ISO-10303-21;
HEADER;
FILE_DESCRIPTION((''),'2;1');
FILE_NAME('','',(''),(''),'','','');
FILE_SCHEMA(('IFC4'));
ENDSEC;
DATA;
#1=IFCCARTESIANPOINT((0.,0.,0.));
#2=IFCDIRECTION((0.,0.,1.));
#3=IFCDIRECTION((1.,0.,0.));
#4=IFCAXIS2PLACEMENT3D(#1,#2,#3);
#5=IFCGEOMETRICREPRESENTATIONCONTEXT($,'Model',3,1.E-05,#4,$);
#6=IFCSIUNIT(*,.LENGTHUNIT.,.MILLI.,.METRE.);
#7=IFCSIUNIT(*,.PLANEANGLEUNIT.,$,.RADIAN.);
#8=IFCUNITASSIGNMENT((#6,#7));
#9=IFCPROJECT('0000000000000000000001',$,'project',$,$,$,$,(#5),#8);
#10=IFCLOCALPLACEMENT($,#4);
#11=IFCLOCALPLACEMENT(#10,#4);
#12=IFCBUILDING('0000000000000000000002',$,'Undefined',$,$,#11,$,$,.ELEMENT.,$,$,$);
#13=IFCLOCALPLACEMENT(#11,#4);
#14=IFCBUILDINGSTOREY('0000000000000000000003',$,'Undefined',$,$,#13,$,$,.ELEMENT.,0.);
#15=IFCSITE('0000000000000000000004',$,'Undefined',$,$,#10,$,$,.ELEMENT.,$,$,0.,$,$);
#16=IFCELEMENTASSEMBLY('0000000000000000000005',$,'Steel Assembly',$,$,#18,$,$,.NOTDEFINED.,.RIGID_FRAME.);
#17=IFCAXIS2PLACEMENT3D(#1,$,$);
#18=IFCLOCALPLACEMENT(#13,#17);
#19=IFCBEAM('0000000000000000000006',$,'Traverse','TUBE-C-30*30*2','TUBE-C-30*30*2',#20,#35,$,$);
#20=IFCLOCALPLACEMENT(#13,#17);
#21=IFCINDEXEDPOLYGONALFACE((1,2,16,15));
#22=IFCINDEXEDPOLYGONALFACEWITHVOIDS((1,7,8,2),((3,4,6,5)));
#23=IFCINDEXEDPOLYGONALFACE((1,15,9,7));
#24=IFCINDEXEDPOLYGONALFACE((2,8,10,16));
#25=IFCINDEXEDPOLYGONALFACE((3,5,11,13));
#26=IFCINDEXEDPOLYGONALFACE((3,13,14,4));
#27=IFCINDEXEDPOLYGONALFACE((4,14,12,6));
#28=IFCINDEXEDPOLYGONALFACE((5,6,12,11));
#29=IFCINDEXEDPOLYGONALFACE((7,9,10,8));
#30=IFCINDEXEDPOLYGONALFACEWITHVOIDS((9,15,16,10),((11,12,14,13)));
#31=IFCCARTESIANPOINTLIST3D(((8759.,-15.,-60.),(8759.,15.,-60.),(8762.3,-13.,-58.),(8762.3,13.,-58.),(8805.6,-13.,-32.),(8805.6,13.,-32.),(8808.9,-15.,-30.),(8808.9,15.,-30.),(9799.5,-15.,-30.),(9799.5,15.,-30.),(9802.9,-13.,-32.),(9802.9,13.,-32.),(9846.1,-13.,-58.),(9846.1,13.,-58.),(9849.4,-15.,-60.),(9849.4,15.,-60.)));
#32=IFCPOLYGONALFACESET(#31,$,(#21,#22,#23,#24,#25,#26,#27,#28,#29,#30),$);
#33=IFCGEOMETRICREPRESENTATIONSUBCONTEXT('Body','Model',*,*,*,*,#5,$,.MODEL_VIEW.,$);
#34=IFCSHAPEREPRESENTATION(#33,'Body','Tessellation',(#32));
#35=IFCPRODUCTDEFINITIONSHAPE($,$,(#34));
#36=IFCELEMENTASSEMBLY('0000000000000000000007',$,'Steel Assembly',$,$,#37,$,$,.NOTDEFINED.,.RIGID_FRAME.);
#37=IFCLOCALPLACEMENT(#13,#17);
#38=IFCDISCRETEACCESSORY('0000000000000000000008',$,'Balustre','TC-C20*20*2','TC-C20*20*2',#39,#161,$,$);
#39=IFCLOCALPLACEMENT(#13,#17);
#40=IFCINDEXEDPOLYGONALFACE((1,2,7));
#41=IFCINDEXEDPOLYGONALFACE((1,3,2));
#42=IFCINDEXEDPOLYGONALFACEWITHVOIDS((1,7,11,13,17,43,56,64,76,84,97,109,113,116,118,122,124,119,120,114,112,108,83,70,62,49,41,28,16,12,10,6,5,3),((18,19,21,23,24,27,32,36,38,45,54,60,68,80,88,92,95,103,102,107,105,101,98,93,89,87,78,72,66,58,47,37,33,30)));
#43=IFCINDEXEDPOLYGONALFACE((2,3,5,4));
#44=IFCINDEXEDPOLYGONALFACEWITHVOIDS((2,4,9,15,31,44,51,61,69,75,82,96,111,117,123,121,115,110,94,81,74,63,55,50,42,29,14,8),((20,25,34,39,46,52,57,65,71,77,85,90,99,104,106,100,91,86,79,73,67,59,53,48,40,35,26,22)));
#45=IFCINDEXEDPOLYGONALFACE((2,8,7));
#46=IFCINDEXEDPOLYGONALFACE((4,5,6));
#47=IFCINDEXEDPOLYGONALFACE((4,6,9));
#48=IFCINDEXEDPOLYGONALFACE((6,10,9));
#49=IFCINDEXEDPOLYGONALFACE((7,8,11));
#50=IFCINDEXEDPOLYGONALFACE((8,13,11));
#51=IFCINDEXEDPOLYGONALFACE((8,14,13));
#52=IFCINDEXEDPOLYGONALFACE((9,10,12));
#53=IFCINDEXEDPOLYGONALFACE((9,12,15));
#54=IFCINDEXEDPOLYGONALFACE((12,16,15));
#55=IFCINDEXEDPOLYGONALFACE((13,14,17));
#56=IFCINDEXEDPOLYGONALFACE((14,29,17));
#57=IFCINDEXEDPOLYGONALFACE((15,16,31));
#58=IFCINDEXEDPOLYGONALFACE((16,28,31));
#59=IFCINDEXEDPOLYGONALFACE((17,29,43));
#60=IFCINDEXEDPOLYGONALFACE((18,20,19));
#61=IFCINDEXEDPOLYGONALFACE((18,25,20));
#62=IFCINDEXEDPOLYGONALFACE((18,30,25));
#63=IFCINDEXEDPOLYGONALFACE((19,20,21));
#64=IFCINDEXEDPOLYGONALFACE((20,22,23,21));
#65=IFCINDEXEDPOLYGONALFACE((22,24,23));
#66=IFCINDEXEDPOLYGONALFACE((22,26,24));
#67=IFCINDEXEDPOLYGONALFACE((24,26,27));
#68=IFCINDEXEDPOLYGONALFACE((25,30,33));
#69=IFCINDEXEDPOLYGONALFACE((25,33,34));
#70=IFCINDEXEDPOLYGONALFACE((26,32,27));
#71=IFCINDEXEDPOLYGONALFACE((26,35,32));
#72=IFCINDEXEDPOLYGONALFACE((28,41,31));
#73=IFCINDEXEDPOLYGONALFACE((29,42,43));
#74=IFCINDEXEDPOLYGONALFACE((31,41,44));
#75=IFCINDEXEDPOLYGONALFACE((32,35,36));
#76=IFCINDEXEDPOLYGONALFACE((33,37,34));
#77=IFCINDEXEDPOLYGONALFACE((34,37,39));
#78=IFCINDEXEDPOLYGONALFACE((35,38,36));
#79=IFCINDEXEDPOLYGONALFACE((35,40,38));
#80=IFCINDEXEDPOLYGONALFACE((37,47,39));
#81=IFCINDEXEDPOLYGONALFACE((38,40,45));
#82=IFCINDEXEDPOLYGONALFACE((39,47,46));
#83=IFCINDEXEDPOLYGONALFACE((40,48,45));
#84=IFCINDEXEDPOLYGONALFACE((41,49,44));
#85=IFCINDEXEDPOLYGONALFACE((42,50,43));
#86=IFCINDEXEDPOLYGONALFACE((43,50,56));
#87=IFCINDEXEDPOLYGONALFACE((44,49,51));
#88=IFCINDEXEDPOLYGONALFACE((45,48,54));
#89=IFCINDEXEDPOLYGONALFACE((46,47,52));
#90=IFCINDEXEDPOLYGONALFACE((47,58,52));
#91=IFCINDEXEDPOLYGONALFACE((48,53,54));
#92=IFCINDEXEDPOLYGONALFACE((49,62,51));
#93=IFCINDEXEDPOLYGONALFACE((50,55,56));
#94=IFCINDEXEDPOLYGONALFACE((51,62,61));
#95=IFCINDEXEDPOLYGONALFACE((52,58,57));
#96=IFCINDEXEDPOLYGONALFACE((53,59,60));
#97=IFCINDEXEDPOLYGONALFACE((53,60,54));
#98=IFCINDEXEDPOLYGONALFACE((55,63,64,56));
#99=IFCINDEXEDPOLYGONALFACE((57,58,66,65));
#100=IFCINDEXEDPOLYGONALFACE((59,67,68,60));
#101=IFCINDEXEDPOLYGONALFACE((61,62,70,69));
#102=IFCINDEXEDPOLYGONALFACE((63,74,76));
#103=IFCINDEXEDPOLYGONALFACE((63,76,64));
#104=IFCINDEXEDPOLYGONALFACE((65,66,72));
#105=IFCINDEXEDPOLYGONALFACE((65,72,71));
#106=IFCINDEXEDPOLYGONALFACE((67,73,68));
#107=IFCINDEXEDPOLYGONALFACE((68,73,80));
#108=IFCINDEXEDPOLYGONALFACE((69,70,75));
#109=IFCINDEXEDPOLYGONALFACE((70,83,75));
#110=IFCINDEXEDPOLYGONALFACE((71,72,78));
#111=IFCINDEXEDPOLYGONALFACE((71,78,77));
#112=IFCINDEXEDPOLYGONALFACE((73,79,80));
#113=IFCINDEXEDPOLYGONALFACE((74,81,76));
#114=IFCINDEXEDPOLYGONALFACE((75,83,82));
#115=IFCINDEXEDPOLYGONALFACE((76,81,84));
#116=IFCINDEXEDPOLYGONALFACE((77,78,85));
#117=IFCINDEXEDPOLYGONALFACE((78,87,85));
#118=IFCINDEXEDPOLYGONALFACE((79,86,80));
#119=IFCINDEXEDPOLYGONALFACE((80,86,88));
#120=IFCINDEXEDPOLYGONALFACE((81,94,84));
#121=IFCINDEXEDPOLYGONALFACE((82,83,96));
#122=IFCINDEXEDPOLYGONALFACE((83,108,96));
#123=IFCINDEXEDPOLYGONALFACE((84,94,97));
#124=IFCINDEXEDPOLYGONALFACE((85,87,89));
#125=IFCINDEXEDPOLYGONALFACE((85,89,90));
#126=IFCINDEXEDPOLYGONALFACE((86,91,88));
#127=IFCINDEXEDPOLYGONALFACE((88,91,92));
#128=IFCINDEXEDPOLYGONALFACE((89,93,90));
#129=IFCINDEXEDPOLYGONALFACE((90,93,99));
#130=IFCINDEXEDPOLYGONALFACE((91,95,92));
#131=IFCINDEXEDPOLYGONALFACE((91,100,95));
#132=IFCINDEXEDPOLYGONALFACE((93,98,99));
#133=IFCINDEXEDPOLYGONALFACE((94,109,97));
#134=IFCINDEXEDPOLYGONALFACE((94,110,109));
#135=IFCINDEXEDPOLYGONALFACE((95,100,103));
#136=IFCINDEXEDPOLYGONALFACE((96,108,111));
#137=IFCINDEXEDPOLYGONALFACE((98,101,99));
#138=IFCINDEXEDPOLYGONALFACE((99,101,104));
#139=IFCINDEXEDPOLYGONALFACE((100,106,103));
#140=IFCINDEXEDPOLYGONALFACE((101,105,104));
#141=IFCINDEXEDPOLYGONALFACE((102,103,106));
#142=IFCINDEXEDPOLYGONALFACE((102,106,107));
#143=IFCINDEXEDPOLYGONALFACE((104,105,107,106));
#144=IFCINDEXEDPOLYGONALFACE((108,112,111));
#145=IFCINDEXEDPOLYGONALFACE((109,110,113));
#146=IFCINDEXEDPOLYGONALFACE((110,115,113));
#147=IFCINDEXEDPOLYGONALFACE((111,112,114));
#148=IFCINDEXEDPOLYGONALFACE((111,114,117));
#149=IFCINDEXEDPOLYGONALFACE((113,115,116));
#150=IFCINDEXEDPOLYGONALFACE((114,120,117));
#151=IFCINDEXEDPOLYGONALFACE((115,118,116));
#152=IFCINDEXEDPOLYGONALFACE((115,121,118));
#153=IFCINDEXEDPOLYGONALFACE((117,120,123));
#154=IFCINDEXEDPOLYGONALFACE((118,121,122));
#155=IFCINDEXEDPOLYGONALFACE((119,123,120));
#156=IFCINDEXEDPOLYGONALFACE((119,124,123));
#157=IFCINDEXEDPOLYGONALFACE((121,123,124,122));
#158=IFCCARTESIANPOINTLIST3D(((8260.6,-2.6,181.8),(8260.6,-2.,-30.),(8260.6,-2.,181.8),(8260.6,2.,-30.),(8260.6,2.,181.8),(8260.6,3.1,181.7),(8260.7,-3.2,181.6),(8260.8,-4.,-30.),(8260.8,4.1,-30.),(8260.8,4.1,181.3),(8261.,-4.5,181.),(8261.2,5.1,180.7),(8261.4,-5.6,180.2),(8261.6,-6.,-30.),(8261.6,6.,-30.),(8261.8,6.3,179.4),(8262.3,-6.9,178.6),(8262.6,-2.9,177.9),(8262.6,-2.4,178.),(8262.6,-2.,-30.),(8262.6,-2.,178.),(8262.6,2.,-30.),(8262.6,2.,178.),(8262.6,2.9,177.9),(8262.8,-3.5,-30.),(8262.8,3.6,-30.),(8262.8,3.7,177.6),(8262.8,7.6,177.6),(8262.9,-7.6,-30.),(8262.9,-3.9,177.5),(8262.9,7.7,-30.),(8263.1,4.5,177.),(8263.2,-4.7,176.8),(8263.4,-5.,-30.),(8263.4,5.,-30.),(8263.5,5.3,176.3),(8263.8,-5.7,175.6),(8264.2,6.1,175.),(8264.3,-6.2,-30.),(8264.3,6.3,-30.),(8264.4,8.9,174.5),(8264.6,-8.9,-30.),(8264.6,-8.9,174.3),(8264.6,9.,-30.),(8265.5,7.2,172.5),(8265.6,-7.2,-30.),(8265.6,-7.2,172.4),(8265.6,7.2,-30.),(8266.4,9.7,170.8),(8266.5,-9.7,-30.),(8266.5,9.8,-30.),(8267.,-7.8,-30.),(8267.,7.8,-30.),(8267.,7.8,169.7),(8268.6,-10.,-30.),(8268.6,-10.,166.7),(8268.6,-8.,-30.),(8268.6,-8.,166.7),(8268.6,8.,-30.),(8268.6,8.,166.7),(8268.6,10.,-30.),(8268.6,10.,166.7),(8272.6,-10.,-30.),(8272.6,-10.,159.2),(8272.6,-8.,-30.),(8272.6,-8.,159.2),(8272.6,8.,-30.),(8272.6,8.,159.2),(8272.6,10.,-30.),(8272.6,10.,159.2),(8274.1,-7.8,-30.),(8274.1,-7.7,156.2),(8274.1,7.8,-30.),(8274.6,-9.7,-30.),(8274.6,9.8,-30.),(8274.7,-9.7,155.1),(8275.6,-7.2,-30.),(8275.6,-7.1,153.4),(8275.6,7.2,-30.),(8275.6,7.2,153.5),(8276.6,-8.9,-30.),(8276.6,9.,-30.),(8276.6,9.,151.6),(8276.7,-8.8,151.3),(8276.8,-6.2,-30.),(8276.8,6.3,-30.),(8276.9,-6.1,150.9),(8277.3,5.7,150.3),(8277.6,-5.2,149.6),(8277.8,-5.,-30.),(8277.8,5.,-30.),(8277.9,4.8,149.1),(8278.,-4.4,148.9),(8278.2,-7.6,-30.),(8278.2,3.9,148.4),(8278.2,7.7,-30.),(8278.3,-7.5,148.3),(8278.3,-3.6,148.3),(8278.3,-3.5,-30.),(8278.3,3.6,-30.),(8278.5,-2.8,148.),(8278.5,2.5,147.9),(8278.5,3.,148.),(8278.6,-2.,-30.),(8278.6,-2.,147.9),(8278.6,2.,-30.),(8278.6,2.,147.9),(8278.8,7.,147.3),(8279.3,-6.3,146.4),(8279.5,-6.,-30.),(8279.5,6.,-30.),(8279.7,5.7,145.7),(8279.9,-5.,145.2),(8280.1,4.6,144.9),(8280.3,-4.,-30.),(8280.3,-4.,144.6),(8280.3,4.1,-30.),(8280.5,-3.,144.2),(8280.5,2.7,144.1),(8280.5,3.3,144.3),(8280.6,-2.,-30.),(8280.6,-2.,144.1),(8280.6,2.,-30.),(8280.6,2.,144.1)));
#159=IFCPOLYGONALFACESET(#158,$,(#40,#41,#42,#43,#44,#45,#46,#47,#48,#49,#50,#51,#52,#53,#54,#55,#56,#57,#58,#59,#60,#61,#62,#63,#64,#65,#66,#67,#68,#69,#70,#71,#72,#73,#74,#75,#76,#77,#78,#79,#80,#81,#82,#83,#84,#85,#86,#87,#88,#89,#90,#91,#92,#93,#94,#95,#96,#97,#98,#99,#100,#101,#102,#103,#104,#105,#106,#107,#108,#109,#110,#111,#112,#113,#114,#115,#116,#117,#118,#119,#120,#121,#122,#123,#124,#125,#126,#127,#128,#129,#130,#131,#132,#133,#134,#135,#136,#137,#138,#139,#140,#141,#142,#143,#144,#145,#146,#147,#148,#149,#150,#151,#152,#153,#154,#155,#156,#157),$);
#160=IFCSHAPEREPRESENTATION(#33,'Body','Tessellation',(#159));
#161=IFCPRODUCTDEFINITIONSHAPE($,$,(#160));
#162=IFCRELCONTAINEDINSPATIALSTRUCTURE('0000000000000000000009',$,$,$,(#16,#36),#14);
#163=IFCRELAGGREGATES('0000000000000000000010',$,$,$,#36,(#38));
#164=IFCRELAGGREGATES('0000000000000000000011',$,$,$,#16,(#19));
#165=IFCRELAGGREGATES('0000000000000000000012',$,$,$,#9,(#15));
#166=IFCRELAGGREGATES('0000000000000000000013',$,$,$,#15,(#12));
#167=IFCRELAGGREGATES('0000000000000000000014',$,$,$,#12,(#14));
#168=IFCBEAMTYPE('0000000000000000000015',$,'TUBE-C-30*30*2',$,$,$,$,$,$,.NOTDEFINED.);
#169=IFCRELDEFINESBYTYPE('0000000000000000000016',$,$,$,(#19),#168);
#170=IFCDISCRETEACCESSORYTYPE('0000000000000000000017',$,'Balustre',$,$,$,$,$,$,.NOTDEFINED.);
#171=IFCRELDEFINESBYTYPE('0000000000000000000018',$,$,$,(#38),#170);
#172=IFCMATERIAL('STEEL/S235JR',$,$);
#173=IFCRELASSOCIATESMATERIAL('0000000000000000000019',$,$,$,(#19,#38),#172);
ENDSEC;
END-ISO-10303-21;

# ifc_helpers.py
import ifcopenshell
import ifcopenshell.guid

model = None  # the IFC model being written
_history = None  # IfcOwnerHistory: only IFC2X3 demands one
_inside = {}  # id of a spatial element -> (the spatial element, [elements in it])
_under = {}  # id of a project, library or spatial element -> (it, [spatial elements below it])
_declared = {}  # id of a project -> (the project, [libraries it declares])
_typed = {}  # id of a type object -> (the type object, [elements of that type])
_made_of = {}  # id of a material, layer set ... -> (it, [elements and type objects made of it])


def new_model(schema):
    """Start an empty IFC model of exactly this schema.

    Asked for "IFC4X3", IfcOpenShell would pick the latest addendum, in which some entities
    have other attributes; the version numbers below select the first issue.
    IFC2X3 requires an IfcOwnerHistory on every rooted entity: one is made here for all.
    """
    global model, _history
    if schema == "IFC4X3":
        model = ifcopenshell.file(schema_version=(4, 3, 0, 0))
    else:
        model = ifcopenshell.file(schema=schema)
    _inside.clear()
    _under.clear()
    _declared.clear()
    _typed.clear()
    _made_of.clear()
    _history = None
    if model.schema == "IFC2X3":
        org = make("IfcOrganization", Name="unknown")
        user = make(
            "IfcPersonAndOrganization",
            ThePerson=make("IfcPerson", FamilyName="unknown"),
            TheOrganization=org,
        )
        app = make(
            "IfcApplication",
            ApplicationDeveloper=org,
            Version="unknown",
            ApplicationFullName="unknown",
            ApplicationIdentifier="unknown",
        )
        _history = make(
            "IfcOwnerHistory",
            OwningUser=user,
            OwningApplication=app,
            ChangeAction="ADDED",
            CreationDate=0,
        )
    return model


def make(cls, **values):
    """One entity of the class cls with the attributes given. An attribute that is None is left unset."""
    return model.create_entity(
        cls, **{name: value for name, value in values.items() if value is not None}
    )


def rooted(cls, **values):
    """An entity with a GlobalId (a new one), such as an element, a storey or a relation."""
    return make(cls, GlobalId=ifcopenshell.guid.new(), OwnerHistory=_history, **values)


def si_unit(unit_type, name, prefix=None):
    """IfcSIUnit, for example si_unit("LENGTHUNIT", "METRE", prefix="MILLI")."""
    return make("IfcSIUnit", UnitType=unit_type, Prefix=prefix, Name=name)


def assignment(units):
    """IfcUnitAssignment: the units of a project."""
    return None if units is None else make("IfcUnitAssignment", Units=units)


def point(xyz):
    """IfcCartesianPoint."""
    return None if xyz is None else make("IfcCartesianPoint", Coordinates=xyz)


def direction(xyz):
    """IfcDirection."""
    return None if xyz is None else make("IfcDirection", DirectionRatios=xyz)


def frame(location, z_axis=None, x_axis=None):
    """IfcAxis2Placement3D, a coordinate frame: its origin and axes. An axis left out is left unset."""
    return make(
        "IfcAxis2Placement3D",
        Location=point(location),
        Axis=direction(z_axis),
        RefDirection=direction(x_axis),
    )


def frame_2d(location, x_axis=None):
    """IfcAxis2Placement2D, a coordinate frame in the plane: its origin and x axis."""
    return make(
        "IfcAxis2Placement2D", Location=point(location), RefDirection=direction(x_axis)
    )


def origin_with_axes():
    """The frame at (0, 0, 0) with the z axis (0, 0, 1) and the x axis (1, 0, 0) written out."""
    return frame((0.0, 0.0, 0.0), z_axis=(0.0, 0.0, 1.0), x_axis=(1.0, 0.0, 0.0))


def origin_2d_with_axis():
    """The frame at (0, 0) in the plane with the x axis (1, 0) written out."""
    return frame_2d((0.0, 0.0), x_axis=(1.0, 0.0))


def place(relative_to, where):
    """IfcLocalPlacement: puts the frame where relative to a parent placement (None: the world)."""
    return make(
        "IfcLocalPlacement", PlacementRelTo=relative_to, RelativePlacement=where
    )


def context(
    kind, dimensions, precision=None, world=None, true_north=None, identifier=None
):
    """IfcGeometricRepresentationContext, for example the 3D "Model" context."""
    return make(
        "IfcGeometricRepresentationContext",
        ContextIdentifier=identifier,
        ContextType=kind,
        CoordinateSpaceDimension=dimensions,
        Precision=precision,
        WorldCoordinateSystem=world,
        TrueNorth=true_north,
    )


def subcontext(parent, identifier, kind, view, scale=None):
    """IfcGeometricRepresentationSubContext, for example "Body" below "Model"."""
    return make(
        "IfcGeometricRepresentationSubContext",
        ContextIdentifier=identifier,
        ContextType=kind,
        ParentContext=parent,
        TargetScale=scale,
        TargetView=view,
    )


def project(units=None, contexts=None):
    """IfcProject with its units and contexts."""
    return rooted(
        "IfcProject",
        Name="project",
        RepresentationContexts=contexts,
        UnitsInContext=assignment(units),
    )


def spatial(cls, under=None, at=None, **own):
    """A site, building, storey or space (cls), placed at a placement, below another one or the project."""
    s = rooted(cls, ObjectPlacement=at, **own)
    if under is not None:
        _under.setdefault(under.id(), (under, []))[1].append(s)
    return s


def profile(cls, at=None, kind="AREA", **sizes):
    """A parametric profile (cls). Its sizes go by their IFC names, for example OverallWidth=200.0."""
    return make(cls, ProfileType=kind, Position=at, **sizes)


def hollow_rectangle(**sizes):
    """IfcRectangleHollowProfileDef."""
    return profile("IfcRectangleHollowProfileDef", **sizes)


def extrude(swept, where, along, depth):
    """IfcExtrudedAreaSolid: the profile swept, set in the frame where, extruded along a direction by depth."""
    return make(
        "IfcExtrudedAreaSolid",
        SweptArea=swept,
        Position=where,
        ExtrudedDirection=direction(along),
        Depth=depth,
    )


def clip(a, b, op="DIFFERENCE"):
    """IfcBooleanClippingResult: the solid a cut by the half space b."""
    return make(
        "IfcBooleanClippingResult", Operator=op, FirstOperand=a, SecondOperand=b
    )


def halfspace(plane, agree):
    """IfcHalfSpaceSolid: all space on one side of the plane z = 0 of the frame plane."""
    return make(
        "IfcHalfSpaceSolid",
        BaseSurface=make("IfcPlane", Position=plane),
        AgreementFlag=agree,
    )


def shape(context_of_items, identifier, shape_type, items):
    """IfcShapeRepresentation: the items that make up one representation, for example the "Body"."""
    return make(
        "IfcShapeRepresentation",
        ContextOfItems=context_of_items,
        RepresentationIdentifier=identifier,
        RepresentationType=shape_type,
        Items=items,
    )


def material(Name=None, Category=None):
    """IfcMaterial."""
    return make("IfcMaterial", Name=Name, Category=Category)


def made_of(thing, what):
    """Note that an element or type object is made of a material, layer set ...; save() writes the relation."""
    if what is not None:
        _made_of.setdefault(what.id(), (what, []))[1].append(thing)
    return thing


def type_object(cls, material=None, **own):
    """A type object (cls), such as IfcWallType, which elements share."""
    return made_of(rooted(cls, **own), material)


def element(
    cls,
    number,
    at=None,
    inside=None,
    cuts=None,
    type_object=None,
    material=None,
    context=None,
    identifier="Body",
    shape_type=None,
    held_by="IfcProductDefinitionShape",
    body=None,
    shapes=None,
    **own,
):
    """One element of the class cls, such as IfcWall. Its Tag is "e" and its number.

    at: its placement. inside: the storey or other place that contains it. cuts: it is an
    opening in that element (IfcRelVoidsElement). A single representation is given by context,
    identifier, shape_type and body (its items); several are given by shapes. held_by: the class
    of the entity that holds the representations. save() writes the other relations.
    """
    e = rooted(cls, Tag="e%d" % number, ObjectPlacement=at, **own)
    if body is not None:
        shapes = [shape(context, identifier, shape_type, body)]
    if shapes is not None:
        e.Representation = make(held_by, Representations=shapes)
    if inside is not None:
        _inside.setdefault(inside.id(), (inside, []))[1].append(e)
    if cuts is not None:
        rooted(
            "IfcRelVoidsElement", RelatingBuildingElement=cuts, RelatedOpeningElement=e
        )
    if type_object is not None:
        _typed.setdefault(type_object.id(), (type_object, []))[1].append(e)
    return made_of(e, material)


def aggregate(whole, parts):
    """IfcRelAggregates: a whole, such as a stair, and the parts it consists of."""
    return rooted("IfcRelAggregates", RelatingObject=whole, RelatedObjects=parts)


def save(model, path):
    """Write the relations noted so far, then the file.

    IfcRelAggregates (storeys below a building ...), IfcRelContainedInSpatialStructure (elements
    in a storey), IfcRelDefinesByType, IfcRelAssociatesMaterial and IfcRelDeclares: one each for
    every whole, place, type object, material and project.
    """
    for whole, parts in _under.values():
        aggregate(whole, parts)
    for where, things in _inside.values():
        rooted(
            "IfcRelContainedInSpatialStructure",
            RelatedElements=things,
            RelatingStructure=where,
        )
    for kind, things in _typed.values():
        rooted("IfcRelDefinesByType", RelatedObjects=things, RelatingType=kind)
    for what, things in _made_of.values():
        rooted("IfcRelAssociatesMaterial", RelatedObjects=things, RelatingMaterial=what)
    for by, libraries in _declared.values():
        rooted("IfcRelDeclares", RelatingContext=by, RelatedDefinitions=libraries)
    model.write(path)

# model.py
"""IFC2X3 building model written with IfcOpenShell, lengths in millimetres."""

from ifc_helpers import new_model, si_unit, frame, origin_with_axes, origin_2d_with_axis, place, context, subcontext, project, spatial, hollow_rectangle, extrude, clip, halfspace, material, type_object, element, aggregate, save


model = new_model("IFC2X3")

# Units and contexts
model_context = context("Model", 3, precision=1e-05, world=origin_with_axes())
body_context = subcontext(model_context, "Body", "Model", "MODEL_VIEW")
ifc_project = project(units=[si_unit("LENGTHUNIT", "METRE", prefix="MILLI"), si_unit("PLANEANGLEUNIT", "RADIAN")], contexts=[model_context])

# Site, building, storey
site_placement = place(None, origin_with_axes())
site = spatial("IfcSite", under=ifc_project, at=site_placement, Name="Undefined", CompositionType="ELEMENT", RefElevation=0.0)
building_placement = place(site_placement, origin_with_axes())
building = spatial("IfcBuilding", under=site, at=building_placement, Name="Undefined", CompositionType="ELEMENT")
storey_placement = place(building_placement, origin_with_axes())
storey = spatial("IfcBuildingStorey", under=building, at=storey_placement, Name="Undefined", CompositionType="ELEMENT", Elevation=0.0)

# Element assembly, beam
assembly_1_placement = place(storey_placement, origin_with_axes())
assembly_1 = element("IfcElementAssembly", 1, at=assembly_1_placement, inside=storey, Name="Steel Assembly", AssemblyPlace="NOTDEFINED", PredefinedType="RIGID_FRAME")
ifc_material = material(Name="STEEL/S235JR")
beam_type = type_object("IfcBeamType", Name="TUBE-C-30*30*2", PredefinedType="NOTDEFINED")
beam_placement = place(assembly_1_placement, frame((8733.6, 0.0, -45.0), z_axis=(0.000011, -1.0, 0.0), x_axis=(1.0, 0.000011, 0.0)))
beam = element("IfcBeam", 2, at=beam_placement, type_object=beam_type, material=ifc_material, Name="Traverse", Description="TUBE-C-30*30*2", ObjectType="TUBE-C-30*30*2", context=body_context, shape_type="Clipping", body=[
    clip(clip(extrude(hollow_rectangle(XDim=30.0, YDim=30.0, WallThickness=2.0, at=origin_2d_with_axis()), frame((1141.2, 0.0, 0.0), z_axis=(-1.0, 0.0, 0.0), x_axis=(0.0, -1.0, 0.0)), (0.0, 0.0, 1.0), 1141.2), halfspace(frame((1065.9, 15.0, 0.0), z_axis=(0.515548, 0.856861, 0.000003), x_axis=(0.000005, 0.0, -1.0)), False)), halfspace(frame((75.3, 15.0, 0.0), z_axis=(0.515548, -0.856861, 0.000003), x_axis=(0.000005, 0.0, -1.0)), True)),
])

# Element assembly, discrete accessory
assembly_2_placement = place(storey_placement, origin_with_axes())
assembly_2 = element("IfcElementAssembly", 3, at=assembly_2_placement, inside=storey, Name="Steel Assembly", AssemblyPlace="NOTDEFINED", PredefinedType="RIGID_FRAME")
discrete_accessory_type_1 = type_object("IfcDiscreteAccessoryType", Name="Balustre")
discrete_accessory_1_placement = place(assembly_2_placement, frame((8270.6, 0.0, -30.0), z_axis=(0.0, 0.0, 1.0), x_axis=(1.0, 0.0, 0.0)))
discrete_accessory_1 = element("IfcDiscreteAccessory", 4, at=discrete_accessory_1_placement, type_object=discrete_accessory_type_1, material=ifc_material, Name="Balustre", Description="TC-C20*20*2", ObjectType="TC-C20*20*2", context=body_context, shape_type="Clipping", body=[
    clip(extrude(hollow_rectangle(XDim=20.0, YDim=20.0, WallThickness=2.0, InnerFilletRadius=6.0, OuterFilletRadius=8.0, at=origin_2d_with_axis()), frame((0.0, 0.0, 212.0), z_axis=(0.0, 0.0, -1.0), x_axis=(-1.0, -0.000011, 0.0)), (0.0, 0.0, 1.0), 212.0), halfspace(frame((22.6, 0.0, 150.3), z_axis=(-0.883506, -0.000005, -0.46842), x_axis=(-0.000005, 1.0, 0.0)), True)),
])

aggregate(assembly_2, [discrete_accessory_1])
aggregate(assembly_1, [beam])

save(model, "model.ifc")
